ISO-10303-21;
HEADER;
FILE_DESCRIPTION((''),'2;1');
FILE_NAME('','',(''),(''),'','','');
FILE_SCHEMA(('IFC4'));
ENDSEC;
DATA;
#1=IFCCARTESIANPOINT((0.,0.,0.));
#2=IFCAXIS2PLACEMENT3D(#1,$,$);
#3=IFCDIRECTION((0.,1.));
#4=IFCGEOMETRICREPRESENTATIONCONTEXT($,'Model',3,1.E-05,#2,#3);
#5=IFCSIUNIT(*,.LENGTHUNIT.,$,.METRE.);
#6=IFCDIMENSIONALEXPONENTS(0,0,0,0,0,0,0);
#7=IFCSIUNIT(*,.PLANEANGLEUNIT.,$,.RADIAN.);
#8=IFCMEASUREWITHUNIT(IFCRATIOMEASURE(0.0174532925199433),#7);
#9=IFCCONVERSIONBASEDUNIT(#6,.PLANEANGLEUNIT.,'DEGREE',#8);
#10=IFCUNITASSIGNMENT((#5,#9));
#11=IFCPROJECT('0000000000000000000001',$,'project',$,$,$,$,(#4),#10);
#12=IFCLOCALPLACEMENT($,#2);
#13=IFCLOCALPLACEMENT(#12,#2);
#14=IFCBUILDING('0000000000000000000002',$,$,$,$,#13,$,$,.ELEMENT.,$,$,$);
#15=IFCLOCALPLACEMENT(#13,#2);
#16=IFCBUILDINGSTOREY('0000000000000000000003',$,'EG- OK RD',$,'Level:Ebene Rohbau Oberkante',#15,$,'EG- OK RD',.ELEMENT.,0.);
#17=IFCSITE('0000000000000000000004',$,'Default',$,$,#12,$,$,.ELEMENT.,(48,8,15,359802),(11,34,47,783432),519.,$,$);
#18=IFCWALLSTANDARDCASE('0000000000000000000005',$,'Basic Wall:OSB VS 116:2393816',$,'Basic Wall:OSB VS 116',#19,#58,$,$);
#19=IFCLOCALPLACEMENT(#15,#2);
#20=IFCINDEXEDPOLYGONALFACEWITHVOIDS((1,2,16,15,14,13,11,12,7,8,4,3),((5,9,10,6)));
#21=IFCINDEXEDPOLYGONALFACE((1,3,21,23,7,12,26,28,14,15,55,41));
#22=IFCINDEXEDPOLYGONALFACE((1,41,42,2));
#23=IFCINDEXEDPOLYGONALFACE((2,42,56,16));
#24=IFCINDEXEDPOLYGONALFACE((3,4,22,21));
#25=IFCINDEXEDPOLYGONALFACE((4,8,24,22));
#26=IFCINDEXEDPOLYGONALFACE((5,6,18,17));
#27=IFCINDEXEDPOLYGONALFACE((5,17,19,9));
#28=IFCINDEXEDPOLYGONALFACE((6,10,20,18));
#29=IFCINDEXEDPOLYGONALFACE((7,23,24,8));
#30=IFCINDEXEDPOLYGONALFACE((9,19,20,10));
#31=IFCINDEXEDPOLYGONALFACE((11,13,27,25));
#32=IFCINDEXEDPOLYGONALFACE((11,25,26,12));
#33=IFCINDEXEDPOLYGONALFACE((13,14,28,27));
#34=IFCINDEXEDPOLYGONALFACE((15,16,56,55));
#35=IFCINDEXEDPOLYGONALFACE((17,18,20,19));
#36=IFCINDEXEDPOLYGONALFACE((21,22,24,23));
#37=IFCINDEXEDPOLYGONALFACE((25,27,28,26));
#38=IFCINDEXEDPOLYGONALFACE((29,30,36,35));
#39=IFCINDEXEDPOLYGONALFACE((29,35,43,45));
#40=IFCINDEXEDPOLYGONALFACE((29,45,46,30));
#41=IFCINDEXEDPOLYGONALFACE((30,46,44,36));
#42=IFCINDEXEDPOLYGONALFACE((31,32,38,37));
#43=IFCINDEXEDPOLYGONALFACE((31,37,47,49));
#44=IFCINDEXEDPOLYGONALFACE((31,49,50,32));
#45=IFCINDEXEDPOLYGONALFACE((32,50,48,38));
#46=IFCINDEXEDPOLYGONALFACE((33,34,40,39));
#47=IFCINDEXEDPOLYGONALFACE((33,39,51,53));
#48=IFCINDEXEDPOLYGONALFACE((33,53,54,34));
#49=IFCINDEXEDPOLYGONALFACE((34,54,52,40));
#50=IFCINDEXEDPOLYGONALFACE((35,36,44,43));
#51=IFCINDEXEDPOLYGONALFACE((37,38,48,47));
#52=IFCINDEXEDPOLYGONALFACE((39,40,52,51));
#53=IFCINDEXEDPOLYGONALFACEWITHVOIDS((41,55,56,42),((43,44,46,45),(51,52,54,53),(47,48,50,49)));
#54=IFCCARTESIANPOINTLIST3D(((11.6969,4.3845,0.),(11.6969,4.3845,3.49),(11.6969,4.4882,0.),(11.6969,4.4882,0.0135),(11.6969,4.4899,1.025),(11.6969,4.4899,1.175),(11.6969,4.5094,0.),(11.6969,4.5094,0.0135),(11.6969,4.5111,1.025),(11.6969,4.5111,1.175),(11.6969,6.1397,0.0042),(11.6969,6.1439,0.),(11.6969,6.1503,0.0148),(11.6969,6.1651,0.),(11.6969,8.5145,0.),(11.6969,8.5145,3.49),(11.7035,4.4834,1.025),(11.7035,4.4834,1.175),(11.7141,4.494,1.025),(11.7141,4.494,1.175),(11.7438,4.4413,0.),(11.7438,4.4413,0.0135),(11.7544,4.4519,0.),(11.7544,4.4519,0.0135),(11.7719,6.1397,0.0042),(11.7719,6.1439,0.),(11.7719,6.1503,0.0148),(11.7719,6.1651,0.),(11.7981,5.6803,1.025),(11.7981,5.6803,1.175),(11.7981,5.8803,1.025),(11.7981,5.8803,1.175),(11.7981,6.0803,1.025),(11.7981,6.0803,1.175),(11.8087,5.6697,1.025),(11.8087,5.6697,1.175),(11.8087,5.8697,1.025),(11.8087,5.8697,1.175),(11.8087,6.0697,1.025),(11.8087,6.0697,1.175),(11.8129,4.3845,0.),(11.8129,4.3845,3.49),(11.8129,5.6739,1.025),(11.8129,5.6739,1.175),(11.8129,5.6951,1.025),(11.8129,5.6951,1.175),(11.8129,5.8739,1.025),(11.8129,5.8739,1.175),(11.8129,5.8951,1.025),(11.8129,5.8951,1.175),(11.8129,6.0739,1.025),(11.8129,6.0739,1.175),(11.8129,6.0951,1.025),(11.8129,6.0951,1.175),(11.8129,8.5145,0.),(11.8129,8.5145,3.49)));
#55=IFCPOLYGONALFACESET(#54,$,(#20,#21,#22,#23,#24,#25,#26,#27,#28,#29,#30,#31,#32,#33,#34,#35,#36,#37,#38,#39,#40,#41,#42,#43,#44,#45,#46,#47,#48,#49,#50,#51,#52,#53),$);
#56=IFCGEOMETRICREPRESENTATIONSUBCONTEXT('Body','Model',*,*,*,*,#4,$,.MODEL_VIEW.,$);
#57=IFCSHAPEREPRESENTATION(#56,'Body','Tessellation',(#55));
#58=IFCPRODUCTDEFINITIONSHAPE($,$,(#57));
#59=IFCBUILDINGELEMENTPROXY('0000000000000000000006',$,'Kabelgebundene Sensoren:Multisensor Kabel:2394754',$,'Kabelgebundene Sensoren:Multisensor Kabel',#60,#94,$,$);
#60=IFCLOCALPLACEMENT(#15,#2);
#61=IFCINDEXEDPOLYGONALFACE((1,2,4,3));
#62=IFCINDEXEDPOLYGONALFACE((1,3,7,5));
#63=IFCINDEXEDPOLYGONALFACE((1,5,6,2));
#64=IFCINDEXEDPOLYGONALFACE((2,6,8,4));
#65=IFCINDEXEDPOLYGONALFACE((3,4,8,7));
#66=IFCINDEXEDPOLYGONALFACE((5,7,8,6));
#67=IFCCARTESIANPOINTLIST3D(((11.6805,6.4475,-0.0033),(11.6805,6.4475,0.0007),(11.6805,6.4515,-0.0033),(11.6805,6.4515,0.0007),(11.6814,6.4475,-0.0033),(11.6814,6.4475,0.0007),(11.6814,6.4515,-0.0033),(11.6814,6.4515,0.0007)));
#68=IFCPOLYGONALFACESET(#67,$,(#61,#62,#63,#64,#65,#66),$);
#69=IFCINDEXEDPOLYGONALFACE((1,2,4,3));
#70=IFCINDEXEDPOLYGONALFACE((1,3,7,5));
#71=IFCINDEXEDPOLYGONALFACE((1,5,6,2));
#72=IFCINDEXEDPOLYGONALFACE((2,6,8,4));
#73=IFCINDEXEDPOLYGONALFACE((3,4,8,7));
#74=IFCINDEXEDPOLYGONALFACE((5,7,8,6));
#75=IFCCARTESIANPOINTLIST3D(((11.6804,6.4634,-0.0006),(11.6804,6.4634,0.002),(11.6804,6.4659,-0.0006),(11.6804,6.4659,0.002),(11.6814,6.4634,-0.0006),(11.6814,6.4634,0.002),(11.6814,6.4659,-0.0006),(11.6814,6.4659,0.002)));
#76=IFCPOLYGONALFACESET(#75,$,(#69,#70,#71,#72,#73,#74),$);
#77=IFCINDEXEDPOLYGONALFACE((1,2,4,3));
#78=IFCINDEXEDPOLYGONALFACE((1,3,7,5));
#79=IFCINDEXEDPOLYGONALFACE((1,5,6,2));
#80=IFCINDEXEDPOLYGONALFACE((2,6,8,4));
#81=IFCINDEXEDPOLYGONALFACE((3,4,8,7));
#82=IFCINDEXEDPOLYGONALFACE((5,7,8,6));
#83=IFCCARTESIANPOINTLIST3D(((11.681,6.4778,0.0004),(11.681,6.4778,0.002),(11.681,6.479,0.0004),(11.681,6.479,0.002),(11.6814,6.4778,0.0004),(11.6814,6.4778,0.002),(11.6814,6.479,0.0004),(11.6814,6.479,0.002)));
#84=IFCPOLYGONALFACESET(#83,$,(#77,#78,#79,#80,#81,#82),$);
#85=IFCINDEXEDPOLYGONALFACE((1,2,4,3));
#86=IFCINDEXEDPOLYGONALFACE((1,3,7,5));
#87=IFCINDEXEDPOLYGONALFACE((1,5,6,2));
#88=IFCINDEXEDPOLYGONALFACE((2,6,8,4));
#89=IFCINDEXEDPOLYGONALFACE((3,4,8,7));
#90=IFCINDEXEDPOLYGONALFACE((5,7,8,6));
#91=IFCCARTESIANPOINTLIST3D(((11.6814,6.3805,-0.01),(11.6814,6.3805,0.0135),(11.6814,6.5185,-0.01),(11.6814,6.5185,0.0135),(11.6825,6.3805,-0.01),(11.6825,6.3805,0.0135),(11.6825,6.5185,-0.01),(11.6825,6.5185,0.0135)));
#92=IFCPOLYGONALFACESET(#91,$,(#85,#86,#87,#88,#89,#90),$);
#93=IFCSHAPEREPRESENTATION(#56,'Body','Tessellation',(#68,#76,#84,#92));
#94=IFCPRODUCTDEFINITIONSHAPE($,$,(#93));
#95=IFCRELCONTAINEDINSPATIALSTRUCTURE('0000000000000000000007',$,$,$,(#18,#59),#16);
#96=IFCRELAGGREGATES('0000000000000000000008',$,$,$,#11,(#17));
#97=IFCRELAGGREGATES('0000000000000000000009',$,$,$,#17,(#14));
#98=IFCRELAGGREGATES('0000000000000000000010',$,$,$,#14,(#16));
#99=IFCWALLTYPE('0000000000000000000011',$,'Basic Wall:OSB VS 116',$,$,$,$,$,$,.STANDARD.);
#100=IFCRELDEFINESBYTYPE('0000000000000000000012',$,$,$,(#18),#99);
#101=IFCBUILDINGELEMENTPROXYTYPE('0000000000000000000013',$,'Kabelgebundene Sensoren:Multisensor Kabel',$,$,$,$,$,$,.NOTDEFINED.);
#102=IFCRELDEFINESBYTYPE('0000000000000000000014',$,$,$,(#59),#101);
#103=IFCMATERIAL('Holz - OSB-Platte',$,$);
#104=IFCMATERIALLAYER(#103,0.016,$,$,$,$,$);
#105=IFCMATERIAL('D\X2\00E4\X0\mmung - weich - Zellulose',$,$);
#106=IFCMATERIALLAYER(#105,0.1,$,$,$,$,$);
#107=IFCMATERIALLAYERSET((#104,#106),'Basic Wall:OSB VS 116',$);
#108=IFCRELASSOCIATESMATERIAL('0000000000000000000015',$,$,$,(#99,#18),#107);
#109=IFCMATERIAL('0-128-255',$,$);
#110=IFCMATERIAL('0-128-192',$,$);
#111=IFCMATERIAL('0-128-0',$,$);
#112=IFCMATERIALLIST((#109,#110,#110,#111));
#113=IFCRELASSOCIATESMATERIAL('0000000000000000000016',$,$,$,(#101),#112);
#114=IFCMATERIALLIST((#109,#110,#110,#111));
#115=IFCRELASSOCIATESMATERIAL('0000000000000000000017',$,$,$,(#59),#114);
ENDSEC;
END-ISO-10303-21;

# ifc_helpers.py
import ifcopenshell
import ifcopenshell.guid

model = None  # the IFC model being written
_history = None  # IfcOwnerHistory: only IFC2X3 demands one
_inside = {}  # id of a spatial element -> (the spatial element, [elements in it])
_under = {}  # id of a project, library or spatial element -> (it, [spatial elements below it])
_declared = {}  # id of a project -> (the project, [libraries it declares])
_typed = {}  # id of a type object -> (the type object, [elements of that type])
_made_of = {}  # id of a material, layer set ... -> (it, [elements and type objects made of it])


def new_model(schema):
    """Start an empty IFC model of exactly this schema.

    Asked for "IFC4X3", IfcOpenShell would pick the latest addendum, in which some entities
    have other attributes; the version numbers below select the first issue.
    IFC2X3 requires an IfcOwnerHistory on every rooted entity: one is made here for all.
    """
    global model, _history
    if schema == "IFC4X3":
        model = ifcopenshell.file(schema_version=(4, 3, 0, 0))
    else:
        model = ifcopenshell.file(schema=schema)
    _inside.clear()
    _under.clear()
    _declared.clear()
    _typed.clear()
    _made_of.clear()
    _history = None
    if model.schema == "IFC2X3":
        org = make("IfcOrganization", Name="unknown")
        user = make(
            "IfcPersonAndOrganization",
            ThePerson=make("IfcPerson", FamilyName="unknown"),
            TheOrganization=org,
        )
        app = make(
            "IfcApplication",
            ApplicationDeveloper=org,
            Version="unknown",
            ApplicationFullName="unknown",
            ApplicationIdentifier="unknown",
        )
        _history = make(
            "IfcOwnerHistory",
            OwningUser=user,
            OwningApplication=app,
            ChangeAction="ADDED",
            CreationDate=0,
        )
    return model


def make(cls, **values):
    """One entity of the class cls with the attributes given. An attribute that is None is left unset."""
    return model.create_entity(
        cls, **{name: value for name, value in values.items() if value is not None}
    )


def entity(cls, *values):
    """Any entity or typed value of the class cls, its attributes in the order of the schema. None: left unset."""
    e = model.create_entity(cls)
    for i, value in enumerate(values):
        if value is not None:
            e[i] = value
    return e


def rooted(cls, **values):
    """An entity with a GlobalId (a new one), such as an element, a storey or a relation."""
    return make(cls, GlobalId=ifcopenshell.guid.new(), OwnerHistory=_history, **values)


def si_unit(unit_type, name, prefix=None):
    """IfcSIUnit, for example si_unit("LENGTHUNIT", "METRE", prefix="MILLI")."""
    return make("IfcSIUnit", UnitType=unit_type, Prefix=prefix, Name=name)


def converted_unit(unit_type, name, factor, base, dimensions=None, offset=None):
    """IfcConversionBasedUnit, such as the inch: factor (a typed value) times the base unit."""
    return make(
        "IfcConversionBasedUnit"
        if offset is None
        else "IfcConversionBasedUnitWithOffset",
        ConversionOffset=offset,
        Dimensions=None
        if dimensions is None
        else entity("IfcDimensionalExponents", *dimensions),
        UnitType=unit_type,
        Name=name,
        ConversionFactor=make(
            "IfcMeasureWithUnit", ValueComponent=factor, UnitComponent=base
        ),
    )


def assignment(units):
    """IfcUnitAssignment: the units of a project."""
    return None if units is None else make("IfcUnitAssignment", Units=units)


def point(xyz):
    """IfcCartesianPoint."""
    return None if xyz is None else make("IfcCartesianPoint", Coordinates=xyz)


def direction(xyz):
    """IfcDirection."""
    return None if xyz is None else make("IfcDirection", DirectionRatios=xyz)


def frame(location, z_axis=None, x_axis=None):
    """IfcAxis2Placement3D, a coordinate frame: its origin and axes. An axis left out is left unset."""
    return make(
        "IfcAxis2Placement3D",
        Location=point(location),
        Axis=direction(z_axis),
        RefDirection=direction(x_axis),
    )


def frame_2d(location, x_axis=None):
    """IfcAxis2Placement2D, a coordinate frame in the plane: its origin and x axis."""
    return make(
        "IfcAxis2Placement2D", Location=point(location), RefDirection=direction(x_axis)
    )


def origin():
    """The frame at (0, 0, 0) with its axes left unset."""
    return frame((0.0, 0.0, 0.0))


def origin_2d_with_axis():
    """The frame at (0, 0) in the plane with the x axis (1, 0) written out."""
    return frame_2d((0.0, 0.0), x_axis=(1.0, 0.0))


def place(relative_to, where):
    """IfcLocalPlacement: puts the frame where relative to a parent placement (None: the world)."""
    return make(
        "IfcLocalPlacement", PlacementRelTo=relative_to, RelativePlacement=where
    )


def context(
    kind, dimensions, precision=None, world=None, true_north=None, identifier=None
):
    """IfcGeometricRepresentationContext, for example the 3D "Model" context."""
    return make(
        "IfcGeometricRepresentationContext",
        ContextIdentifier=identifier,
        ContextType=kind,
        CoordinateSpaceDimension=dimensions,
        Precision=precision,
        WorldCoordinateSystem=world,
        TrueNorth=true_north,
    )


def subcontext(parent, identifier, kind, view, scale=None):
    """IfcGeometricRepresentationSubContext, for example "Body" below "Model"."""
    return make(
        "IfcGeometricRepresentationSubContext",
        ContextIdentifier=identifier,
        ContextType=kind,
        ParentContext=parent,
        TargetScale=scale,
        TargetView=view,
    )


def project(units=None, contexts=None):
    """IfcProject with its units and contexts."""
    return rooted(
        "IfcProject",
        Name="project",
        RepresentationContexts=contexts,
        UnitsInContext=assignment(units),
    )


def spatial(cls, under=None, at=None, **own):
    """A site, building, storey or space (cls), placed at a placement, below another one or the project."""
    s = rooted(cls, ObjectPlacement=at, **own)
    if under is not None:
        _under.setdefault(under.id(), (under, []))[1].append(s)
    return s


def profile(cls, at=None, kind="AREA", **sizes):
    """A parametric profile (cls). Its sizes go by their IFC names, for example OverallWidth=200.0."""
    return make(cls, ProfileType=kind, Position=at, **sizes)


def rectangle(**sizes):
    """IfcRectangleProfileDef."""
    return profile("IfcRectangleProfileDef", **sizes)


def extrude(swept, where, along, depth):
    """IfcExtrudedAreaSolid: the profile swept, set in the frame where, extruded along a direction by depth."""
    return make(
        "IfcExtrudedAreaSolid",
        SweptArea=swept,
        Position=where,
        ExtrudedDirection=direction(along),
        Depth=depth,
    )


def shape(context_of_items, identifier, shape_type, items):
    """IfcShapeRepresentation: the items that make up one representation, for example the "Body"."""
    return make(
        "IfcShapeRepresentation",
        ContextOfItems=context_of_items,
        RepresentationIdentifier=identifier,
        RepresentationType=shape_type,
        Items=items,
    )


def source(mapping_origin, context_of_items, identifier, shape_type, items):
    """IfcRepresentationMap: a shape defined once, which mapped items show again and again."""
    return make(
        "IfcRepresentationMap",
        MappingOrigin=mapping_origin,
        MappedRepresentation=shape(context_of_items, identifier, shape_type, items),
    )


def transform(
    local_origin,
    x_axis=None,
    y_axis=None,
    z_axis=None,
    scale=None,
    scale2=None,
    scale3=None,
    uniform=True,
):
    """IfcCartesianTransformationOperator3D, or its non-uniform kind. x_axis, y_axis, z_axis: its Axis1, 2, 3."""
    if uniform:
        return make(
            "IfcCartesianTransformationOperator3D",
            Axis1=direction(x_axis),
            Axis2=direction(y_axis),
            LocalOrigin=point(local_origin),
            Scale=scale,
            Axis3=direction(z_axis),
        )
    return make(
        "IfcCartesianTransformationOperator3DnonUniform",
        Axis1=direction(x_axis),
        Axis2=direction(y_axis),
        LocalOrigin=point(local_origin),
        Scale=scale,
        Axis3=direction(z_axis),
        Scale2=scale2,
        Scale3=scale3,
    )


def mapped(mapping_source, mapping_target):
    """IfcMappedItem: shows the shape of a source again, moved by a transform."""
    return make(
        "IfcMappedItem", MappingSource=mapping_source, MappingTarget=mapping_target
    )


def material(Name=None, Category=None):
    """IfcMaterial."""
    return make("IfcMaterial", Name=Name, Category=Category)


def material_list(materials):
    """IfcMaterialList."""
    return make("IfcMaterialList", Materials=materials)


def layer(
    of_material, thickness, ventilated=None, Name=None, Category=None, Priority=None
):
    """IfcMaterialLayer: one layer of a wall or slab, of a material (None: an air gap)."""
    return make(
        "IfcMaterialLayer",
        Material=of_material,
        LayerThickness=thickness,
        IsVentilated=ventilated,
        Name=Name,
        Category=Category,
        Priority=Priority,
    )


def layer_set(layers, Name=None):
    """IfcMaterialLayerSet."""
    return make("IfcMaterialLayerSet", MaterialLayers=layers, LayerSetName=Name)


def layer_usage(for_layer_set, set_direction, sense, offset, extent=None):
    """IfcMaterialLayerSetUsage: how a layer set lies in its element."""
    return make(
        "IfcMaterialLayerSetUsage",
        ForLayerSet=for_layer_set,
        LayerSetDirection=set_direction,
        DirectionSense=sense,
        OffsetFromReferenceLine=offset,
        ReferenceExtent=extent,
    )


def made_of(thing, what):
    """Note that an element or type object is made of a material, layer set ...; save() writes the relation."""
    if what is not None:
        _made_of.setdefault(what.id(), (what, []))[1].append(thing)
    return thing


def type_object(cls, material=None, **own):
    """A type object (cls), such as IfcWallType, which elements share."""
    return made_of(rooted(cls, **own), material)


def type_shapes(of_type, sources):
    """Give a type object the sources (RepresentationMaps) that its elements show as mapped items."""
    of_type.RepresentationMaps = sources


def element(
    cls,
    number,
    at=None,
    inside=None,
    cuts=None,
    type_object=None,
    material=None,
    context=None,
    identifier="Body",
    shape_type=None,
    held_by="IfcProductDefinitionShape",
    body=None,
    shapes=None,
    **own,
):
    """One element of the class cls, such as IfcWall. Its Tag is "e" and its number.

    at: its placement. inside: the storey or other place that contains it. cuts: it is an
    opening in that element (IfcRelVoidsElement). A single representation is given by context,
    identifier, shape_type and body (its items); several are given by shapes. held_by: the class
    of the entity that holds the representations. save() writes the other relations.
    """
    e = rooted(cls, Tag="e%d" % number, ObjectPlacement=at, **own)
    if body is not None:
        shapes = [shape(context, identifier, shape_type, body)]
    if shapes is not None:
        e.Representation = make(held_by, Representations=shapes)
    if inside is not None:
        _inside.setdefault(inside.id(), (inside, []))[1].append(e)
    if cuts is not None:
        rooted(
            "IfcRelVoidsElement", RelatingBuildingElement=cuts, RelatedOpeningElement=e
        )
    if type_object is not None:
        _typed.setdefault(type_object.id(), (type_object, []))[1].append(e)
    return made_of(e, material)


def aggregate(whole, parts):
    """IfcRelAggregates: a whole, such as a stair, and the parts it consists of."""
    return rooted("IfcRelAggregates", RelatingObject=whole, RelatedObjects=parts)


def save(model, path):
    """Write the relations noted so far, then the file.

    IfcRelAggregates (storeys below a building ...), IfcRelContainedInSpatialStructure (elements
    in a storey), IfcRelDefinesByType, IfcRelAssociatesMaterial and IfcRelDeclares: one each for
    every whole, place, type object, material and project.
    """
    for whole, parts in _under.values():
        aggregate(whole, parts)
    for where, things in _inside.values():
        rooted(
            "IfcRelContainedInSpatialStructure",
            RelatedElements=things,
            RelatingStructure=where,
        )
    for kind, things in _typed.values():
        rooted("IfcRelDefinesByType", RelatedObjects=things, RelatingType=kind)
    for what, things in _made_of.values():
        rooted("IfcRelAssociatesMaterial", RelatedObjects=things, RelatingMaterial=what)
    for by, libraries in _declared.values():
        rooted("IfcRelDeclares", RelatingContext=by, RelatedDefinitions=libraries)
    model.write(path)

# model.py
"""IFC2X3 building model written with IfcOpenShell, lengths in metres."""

from ifc_helpers import new_model, entity, si_unit, converted_unit, direction, frame, frame_2d, origin, origin_2d_with_axis, place, context, subcontext, project, spatial, rectangle, extrude, source, transform, mapped, material, material_list, layer, layer_set, layer_usage, type_object, type_shapes, element, save


model = new_model("IFC2X3")

# Units and contexts
model_context = context("Model", 3, precision=1e-05, world=origin(), true_north=direction((0.0, 1.0)))
body_context = subcontext(model_context, "Body", "Model", "MODEL_VIEW")
ifc_project = project(units=[si_unit("LENGTHUNIT", "METRE"), converted_unit("PLANEANGLEUNIT", "DEGREE", entity("IfcRatioMeasure", 0.0174532925199433), si_unit("PLANEANGLEUNIT", "RADIAN"), dimensions=[0, 0, 0, 0, 0, 0, 0])], contexts=[model_context])

# Site, building, storey
site_placement = place(None, origin())
site = spatial("IfcSite", under=ifc_project, at=site_placement, Name="Default", CompositionType="ELEMENT", RefLatitude=(48, 8, 15, 359802), RefLongitude=(11, 34, 47, 783432), RefElevation=519.0)
building_placement = place(site_placement, origin())
building = spatial("IfcBuilding", under=site, at=building_placement, CompositionType="ELEMENT")
storey_placement = place(building_placement, origin())
storey = spatial("IfcBuildingStorey", under=building, at=storey_placement, Name="EG- OK RD", ObjectType="Level:Ebene Rohbau Oberkante", LongName="EG- OK RD", CompositionType="ELEMENT", Elevation=0.0)

# Wall, openings
ifc_material_1 = material(Name="Holz - OSB-Platte")
ifc_layer_1 = layer(ifc_material_1, 0.016)
ifc_material_2 = material(Name="Dämmung - weich - Zellulose")
ifc_layer_2 = layer(ifc_material_2, 0.1)
ifc_layer_set_1 = layer_set([ifc_layer_1, ifc_layer_2], Name="Basic Wall:OSB VS 116")
ifc_layer_usage_1 = layer_usage(ifc_layer_set_1, "AXIS2", "NEGATIVE", 0.058)
wall_type_1 = type_object("IfcWallType", Name="Basic Wall:OSB VS 116", PredefinedType="STANDARD", material=ifc_layer_set_1)
wall_1_placement = place(storey_placement, frame((11.7549, 4.3845, 0.0), z_axis=(0.0, 0.0, 1.0), x_axis=(0.0, 1.0, 0.0)))
wall_1 = element("IfcWallStandardCase", 1, at=wall_1_placement, inside=storey, type_object=wall_type_1, material=ifc_layer_usage_1, Name="Basic Wall:OSB VS 116:2393816", ObjectType="Basic Wall:OSB VS 116", context=body_context, shape_type="SweptSolid", body=[
    extrude(rectangle(XDim=4.13, YDim=0.116, at=frame_2d((2.065, 0.0), x_axis=(-1.0, 0.0))), origin(), (0.0, 0.0, 1.0), 3.49),
])
opening_1_placement = place(wall_1_placement, origin())
element("IfcOpeningElement", 2, at=opening_1_placement, cuts=wall_1, ObjectType="Recess", context=body_context, shape_type="SweptSolid", body=[
    extrude(rectangle(XDim=0.15, YDim=0.0285, at=frame_2d((0.0, 0.0), x_axis=(0.0, 1.0))), frame((1.2952, -0.0638, 1.1), z_axis=(0.707107, 0.707107, 0.0), x_axis=(0.707107, -0.707107, 0.0)), (0.0, 0.0, 1.0), 0.015),
])
opening_2_placement = place(wall_1_placement, origin())
element("IfcOpeningElement", 3, at=opening_2_placement, cuts=wall_1, ObjectType="Recess", context=body_context, shape_type="SweptSolid", body=[
    extrude(rectangle(XDim=0.15, YDim=0.0285, at=frame_2d((0.0, 0.0), x_axis=(0.0, 1.0))), frame((1.4952, -0.0638, 1.1), z_axis=(0.707107, 0.707107, 0.0), x_axis=(0.707107, -0.707107, 0.0)), (0.0, 0.0, 1.0), 0.015),
])
opening_3_placement = place(wall_1_placement, origin())
element("IfcOpeningElement", 4, at=opening_3_placement, cuts=wall_1, ObjectType="Recess", context=body_context, shape_type="SweptSolid", body=[
    extrude(rectangle(XDim=0.15, YDim=0.0285, at=frame_2d((0.0, 0.0), x_axis=(0.0, 1.0))), frame((1.6952, -0.0638, 1.1), z_axis=(0.707107, 0.707107, 0.0), x_axis=(0.707107, -0.707107, 0.0)), (0.0, 0.0, 1.0), 0.015),
])
opening_4_placement = place(wall_1_placement, origin())
element("IfcOpeningElement", 5, at=opening_4_placement, cuts=wall_1, ObjectType="Recess", context=body_context, shape_type="SweptSolid", body=[
    extrude(rectangle(XDim=0.15, YDim=0.0285, at=frame_2d((0.0, 0.0), x_axis=(0.0, 1.0))), frame((0.1195, 0.0509, 1.1), z_axis=(-0.707107, 0.707107, 0.0), x_axis=(-0.707107, -0.707107, 0.0)), (0.0, 0.0, 1.0), 0.015),
])
opening_5_placement = place(wall_1_placement, origin())
element("IfcOpeningElement", 6, at=opening_5_placement, cuts=wall_1, ObjectType="Recess", context=body_context, shape_type="SweptSolid", body=[
    extrude(rectangle(XDim=0.0285, YDim=0.15, at=frame_2d((0.0, 0.0), x_axis=(1.0, 0.0))), frame((0.1205, 0.0535, -0.0007), z_axis=(-0.707107, 0.707107, 0.0), x_axis=(0.0, 0.0, -1.0)), (0.0, 0.0, 1.0), 0.015),
])
opening_6_placement = place(wall_1_placement, origin())
element("IfcOpeningElement", 7, at=opening_6_placement, cuts=wall_1, ObjectType="Opening", context=body_context, shape_type="SweptSolid", body=[
    extrude(rectangle(XDim=0.0285, YDim=0.015, at=origin_2d_with_axis()), frame((1.7705, -0.017, -0.0005), z_axis=(0.0, 1.0, 0.0), x_axis=(0.707107, 0.0, -0.707107)), (0.0, 0.0, 1.0), 0.15),
])

# Building element proxy
ifc_material_3 = material(Name="0-128-255")
ifc_material_4 = material(Name="0-128-192")
ifc_material_5 = material(Name="0-128-0")
ifc_material_list_1 = material_list([ifc_material_3, ifc_material_4, ifc_material_4, ifc_material_5])
ifc_material_list_2 = material_list([ifc_material_3, ifc_material_4, ifc_material_4, ifc_material_5])
building_element_proxy_type_1 = type_object("IfcBuildingElementProxyType", Name="Kabelgebundene Sensoren:Multisensor Kabel", PredefinedType="NOTDEFINED", material=ifc_material_list_2)
shared_shape_1 = source(origin(), body_context, "Body", "SweptSolid", [
    extrude(rectangle(XDim=0.0009, YDim=0.004, at=frame_2d((0.0, 0.0), x_axis=(1.0, 0.0))), frame((0.0, 0.001, -0.0033), z_axis=(0.0, 0.0, 1.0), x_axis=(0.0, -1.0, 0.0)), (0.0, 0.0, 1.0), 0.004),
    extrude(rectangle(XDim=0.001, YDim=0.0025, at=frame_2d((0.0, 0.0), x_axis=(1.0, 0.0))), frame((0.0152, 0.001, -0.0006), z_axis=(0.0, 0.0, 1.0), x_axis=(0.0, -1.0, 0.0)), (0.0, 0.0, 1.0), 0.0026),
    extrude(rectangle(XDim=0.0004, YDim=0.0012, at=frame_2d((0.0, 0.0), x_axis=(1.0, 0.0))), frame((0.0289, 0.0007, 0.0004), z_axis=(0.0, 0.0, 1.0), x_axis=(0.0, -1.0, 0.0)), (0.0, 0.0, 1.0), 0.0016),
    extrude(rectangle(XDim=0.0011, YDim=0.138, at=origin_2d_with_axis()), frame((0.0, 0.0, -0.01), z_axis=(0.0, 0.0, 1.0), x_axis=(0.0, 1.0, 0.0)), (0.0, 0.0, 1.0), 0.0235),
])
type_shapes(building_element_proxy_type_1, [shared_shape_1])
proxy_1_placement = place(storey_placement, frame((11.6819, 6.4495, 0.0), z_axis=(0.0, 0.0, 1.0), x_axis=(0.0, 1.0, 0.0)))
element("IfcBuildingElementProxy", 8, at=proxy_1_placement, inside=storey, type_object=building_element_proxy_type_1, material=ifc_material_list_1, Name="Kabelgebundene Sensoren:Multisensor Kabel:2394754", ObjectType="Kabelgebundene Sensoren:Multisensor Kabel", context=body_context, shape_type="MappedRepresentation", body=[
    mapped(shared_shape_1, transform((0.0, 0.0, 0.0), scale=1.0)),
])

save(model, "model.ifc")
